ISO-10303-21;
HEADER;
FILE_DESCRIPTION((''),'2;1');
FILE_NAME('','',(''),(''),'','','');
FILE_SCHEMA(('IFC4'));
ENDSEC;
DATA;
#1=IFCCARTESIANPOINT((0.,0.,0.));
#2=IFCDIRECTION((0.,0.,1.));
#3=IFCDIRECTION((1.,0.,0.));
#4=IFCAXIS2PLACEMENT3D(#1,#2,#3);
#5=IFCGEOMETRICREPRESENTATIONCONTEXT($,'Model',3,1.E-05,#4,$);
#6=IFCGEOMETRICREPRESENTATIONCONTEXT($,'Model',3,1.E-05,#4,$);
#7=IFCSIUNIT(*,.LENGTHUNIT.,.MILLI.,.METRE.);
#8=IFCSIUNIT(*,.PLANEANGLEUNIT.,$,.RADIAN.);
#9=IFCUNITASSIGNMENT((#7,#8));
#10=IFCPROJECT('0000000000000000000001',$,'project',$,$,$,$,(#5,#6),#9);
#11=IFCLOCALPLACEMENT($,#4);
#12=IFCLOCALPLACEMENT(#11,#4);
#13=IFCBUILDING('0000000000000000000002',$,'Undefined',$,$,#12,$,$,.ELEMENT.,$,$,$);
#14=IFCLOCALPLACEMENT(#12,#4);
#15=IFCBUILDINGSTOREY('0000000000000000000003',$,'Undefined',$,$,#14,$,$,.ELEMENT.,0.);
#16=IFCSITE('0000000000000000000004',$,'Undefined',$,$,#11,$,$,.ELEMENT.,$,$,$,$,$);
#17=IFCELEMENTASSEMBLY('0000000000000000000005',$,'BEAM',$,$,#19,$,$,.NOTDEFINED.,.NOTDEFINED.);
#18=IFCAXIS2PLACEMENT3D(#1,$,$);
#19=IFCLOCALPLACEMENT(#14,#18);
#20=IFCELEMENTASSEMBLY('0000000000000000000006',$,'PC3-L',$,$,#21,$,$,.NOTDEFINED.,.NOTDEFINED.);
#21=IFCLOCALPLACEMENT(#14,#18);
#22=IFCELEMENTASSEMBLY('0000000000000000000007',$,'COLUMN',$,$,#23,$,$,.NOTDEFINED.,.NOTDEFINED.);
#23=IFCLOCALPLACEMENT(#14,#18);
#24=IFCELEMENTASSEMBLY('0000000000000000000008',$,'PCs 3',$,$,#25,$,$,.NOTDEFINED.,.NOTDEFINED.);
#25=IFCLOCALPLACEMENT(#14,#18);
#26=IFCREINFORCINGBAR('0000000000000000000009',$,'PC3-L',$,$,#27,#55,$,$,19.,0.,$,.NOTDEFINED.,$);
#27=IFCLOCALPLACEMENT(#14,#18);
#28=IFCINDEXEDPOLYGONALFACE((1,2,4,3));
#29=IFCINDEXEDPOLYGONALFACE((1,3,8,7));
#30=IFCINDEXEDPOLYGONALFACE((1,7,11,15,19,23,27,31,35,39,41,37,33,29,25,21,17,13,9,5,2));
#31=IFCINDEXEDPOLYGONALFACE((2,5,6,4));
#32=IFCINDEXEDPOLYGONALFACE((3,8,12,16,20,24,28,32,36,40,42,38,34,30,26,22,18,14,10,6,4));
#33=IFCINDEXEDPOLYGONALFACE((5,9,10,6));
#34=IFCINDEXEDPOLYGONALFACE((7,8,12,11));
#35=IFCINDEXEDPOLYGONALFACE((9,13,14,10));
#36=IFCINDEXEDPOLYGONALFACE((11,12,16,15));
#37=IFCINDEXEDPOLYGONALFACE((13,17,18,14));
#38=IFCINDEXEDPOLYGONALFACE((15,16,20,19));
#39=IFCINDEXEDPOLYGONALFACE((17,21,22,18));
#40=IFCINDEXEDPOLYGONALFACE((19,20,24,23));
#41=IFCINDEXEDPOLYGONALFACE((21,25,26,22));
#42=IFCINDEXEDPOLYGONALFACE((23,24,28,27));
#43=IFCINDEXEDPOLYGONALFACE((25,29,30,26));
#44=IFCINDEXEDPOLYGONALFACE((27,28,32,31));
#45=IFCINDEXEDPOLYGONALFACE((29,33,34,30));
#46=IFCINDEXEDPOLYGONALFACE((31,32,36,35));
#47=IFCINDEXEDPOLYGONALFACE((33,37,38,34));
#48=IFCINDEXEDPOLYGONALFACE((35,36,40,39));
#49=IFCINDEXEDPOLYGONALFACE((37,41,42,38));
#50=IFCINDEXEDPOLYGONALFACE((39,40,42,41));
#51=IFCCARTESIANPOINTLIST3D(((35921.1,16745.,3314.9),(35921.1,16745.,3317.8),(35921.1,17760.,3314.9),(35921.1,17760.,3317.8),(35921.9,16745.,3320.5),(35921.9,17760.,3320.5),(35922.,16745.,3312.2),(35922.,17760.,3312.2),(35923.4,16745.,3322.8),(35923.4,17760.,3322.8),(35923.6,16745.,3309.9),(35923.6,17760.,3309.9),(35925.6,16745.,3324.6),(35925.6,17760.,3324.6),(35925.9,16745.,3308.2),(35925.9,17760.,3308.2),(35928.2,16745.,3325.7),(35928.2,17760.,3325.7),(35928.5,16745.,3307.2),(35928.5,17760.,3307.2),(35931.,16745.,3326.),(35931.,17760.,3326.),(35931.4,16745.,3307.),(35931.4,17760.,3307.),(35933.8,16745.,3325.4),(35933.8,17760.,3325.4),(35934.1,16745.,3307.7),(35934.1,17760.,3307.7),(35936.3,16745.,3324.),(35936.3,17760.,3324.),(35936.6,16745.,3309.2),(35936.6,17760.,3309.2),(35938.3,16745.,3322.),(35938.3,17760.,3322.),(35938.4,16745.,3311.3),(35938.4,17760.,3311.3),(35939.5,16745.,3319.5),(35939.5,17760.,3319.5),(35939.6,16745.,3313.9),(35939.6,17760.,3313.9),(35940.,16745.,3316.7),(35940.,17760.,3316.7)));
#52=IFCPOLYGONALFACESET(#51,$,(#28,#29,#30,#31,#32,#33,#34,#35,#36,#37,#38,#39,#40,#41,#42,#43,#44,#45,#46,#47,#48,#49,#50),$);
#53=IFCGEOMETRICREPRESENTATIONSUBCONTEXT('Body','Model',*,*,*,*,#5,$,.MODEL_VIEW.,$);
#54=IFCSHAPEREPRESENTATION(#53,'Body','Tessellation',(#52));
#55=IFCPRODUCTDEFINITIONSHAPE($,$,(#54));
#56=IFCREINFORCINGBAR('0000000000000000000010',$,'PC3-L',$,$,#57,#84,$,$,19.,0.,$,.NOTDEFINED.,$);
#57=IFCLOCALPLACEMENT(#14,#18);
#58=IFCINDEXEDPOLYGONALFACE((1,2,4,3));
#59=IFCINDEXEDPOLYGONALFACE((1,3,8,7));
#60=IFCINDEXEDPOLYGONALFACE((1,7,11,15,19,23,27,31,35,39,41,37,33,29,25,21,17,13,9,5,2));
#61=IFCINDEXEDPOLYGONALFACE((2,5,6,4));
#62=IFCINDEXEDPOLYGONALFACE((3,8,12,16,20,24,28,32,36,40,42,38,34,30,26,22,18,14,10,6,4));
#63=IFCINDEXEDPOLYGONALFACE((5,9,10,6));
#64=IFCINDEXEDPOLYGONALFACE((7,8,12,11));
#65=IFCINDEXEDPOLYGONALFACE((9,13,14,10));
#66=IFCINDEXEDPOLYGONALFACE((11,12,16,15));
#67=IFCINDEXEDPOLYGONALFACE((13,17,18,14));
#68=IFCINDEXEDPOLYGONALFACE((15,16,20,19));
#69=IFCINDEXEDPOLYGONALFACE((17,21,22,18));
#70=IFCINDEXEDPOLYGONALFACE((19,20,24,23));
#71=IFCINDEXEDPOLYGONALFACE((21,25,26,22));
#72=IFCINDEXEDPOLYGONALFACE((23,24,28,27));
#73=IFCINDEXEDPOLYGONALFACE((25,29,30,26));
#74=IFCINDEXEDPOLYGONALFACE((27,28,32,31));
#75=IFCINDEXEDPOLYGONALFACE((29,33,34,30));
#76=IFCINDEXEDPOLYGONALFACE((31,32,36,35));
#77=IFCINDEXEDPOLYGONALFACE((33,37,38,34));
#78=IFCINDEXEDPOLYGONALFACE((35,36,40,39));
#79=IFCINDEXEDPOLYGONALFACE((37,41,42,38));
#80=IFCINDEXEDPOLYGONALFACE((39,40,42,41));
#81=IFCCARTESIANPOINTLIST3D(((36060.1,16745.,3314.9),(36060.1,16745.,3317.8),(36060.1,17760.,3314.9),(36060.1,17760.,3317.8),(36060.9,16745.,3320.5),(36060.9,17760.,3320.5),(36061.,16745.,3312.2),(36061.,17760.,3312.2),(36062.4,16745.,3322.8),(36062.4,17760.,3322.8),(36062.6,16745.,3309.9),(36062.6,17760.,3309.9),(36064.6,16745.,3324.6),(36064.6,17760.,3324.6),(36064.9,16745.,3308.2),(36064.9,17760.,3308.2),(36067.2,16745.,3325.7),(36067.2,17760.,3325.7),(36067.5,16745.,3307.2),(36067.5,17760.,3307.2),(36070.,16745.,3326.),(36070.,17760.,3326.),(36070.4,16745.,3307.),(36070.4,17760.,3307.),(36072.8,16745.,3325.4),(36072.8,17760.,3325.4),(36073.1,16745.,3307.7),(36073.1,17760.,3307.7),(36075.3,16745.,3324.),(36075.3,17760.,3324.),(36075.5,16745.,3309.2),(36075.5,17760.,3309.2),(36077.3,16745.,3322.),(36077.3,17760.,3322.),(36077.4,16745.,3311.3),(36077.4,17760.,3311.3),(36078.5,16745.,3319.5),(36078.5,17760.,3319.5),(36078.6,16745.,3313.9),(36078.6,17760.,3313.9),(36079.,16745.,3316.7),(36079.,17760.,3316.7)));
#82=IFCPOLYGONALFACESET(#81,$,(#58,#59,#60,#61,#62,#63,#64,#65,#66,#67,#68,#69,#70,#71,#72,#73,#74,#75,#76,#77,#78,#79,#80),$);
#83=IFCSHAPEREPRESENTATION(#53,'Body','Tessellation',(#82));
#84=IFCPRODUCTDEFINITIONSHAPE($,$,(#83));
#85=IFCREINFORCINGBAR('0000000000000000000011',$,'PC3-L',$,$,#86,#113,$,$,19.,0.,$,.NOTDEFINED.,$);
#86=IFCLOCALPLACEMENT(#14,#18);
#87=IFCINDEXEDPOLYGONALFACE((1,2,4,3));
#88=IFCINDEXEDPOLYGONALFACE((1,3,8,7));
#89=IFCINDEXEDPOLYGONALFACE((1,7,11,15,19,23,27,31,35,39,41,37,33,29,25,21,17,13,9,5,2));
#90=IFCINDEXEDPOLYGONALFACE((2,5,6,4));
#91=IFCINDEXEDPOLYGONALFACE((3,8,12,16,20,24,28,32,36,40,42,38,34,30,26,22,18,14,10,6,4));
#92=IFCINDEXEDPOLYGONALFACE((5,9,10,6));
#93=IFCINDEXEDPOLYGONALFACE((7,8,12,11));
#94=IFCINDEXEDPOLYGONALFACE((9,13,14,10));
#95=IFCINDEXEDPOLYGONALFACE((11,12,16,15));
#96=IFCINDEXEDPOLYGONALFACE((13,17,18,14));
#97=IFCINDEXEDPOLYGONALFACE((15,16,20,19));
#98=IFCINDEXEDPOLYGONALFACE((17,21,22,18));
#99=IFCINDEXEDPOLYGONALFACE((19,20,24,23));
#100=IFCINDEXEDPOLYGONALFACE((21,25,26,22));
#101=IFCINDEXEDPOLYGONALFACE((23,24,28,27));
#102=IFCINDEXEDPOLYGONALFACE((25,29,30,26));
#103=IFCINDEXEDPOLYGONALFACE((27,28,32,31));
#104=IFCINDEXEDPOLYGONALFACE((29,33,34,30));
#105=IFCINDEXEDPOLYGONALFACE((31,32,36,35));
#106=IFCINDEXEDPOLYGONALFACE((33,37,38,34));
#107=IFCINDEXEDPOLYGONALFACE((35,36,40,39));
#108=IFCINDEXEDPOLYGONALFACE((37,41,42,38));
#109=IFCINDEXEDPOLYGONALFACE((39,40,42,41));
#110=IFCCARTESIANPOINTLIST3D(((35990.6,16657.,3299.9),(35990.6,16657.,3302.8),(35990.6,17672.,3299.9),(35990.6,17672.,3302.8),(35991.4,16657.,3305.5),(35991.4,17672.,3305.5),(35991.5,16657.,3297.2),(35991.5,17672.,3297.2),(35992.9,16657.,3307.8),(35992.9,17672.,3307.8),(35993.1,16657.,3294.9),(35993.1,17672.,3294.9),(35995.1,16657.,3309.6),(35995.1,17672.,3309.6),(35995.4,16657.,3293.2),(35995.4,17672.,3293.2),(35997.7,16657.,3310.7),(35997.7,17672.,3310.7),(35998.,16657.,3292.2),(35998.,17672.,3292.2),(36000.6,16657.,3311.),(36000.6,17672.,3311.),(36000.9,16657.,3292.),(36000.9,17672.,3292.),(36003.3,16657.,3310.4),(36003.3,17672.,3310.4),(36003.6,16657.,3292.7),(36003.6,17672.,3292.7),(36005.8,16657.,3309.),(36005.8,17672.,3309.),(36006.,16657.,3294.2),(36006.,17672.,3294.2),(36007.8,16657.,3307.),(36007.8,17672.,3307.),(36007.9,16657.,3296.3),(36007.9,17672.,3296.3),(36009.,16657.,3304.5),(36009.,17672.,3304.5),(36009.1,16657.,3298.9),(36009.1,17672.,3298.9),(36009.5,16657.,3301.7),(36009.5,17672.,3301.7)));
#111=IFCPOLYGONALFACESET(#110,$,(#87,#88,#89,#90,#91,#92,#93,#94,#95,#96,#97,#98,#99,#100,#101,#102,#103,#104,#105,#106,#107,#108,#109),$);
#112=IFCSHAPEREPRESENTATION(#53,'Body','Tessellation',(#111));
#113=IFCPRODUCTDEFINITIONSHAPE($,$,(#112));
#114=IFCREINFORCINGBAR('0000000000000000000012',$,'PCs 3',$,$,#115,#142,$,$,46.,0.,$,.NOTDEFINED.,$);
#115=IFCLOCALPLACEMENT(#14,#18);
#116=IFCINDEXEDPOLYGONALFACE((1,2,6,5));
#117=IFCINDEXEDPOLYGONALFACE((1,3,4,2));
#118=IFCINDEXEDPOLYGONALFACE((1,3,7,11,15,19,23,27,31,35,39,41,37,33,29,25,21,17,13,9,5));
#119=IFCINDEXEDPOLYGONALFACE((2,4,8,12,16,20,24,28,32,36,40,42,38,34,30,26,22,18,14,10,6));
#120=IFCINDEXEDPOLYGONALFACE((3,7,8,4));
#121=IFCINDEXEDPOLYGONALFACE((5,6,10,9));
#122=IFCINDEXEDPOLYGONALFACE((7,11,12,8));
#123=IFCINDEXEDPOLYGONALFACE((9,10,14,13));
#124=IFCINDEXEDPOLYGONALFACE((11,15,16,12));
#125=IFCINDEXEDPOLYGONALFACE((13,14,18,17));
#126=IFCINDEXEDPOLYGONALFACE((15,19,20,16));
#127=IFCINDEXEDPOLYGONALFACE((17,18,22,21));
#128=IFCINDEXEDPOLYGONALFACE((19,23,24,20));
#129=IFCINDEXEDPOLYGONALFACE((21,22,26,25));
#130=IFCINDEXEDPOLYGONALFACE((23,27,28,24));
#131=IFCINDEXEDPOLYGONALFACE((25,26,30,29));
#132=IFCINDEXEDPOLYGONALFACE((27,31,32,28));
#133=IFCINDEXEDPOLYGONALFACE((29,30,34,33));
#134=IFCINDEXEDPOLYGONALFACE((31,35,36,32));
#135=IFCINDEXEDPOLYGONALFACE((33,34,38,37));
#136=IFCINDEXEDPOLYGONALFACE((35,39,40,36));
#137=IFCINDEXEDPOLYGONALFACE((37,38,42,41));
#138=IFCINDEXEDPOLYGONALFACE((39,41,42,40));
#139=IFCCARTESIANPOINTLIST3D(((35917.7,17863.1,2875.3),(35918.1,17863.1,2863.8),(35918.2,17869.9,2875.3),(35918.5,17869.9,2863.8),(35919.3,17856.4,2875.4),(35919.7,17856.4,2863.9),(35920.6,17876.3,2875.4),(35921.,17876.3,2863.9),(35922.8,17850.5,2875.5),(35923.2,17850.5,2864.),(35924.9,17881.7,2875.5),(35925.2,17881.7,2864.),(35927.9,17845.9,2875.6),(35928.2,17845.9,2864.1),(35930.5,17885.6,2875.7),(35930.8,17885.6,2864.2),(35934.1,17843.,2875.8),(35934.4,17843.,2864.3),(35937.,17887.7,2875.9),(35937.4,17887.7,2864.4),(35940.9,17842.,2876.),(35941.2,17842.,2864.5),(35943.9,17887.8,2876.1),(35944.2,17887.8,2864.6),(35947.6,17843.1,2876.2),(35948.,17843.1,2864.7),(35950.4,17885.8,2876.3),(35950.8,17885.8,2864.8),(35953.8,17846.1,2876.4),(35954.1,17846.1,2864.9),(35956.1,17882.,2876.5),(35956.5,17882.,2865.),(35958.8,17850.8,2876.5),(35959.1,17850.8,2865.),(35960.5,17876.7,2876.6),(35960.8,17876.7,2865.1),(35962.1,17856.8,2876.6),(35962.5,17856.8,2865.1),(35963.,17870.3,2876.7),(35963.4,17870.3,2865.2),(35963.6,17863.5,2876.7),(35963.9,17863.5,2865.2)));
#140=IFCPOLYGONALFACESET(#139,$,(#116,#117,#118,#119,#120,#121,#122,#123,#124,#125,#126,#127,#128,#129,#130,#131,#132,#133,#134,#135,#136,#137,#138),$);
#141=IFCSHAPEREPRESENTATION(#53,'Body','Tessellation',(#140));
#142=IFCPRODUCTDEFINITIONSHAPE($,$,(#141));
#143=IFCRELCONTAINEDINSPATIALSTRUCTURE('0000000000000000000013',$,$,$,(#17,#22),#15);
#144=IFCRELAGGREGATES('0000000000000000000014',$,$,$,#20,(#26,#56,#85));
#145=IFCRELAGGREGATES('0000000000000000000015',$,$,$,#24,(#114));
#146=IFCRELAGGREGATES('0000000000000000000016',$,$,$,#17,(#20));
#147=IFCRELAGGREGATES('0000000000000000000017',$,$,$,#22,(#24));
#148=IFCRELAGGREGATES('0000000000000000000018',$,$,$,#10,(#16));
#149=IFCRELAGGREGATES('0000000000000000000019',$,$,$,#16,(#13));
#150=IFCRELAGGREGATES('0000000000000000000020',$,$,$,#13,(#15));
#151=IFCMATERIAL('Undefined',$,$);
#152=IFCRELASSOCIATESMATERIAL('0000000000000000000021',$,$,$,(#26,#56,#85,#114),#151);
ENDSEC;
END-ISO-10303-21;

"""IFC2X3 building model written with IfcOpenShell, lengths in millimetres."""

from ifc_helpers import new_model, entity, si_unit, frame, origin_with_axes, place, context, subcontext, project, spatial, source, transform, mapped, material, element, aggregate, save


model = new_model("IFC2X3")

# Units and contexts
model_context_1 = context("Model", 3, precision=1e-05, world=origin_with_axes())
model_context_2 = context("Model", 3, precision=1e-05, world=origin_with_axes())
body_context = subcontext(model_context_1, "Body", "Model", "MODEL_VIEW")
ifc_project = project(units=[si_unit("LENGTHUNIT", "METRE", prefix="MILLI"), si_unit("PLANEANGLEUNIT", "RADIAN")], contexts=[model_context_1, model_context_2])

# Site, building, storey
site_placement = place(None, origin_with_axes())
site = spatial("IfcSite", under=ifc_project, at=site_placement, Name="Undefined", CompositionType="ELEMENT")
building_placement = place(site_placement, origin_with_axes())
building = spatial("IfcBuilding", under=site, at=building_placement, Name="Undefined", CompositionType="ELEMENT")
storey_placement = place(building_placement, origin_with_axes())
storey = spatial("IfcBuildingStorey", under=building, at=storey_placement, Name="Undefined", CompositionType="ELEMENT", Elevation=0.0)

# Element assemblies
assembly_1_placement = place(storey_placement, origin_with_axes())
assembly_1 = element("IfcElementAssembly", 1, at=assembly_1_placement, inside=storey, Name="BEAM", AssemblyPlace="NOTDEFINED", PredefinedType="NOTDEFINED")
assembly_2_placement = place(assembly_1_placement, origin_with_axes())
assembly_2 = element("IfcElementAssembly", 2, at=assembly_2_placement, Name="PC3-L", AssemblyPlace="NOTDEFINED", PredefinedType="NOTDEFINED")

# Element assemblies
assembly_3_placement = place(storey_placement, origin_with_axes())
assembly_3 = element("IfcElementAssembly", 3, at=assembly_3_placement, inside=storey, Name="COLUMN", AssemblyPlace="NOTDEFINED", PredefinedType="NOTDEFINED")
assembly_4_placement = place(assembly_3_placement, origin_with_axes())
assembly_4 = element("IfcElementAssembly", 4, at=assembly_4_placement, Name="PCs 3", AssemblyPlace="NOTDEFINED", PredefinedType="NOTDEFINED")

# Reinforcing bars
ifc_material_1 = material(Name="Undefined")
shared_shape_1 = source(origin_with_axes(), body_context, "Body", "AdvancedSweptSolid", [
    entity("IfcSweptDiskSolid", entity("IfcTrimmedCurve", entity("IfcLine", entity("IfcCartesianPoint", [0.0, 0.0, 0.0]), entity("IfcVector", entity("IfcDirection", [1.0, 0.0, 0.0]), 1.0)), [entity("IfcParameterValue", 0.0)], [entity("IfcParameterValue", 1015.0)], True, "PARAMETER"), 9.5, None, 0.0, 1015.0),
])
reinforcing_bar_1_placement = place(assembly_2_placement, frame((35930.5, 17760.0, 3316.5), z_axis=(0.091912, 0.0, -0.995767), x_axis=(0.0, -1.0, 0.0)))
reinforcing_bar_1 = element("IfcReinforcingBar", 5, at=reinforcing_bar_1_placement, material=ifc_material_1, Name="PC3-L", BarRole="NOTDEFINED", CrossSectionArea=0.0, NominalDiameter=19.0, context=body_context, shape_type="MappedRepresentation", body=[
    mapped(shared_shape_1, transform((0.0, 0.0, 0.0))),
])
shared_shape_2 = source(origin_with_axes(), body_context, "Body", "AdvancedSweptSolid", [
    entity("IfcSweptDiskSolid", entity("IfcTrimmedCurve", entity("IfcLine", entity("IfcCartesianPoint", [0.0, 0.0, 0.0]), entity("IfcVector", entity("IfcDirection", [1.0, 0.0, 0.0]), 1.0)), [entity("IfcParameterValue", 0.0)], [entity("IfcParameterValue", 1015.0)], True, "PARAMETER"), 9.5, None, 0.0, 1015.0),
])
reinforcing_bar_2_placement = place(assembly_2_placement, frame((36069.5, 17760.0, 3316.5), z_axis=(0.091561, 0.0, -0.995799), x_axis=(0.0, -1.0, 0.0)))
reinforcing_bar_2 = element("IfcReinforcingBar", 6, at=reinforcing_bar_2_placement, material=ifc_material_1, Name="PC3-L", BarRole="NOTDEFINED", CrossSectionArea=0.0, NominalDiameter=19.0, context=body_context, shape_type="MappedRepresentation", body=[
    mapped(shared_shape_2, transform((0.0, 0.0, 0.0))),
])
shared_shape_3 = source(origin_with_axes(), body_context, "Body", "AdvancedSweptSolid", [
    entity("IfcSweptDiskSolid", entity("IfcTrimmedCurve", entity("IfcLine", entity("IfcCartesianPoint", [0.0, 0.0, 0.0]), entity("IfcVector", entity("IfcDirection", [1.0, 0.0, 0.0]), 1.0)), [entity("IfcParameterValue", 0.0)], [entity("IfcParameterValue", 1015.0)], True, "PARAMETER"), 9.5, None, 0.0, 1015.0),
])
reinforcing_bar_3_placement = place(assembly_2_placement, frame((36000.0, 17672.0, 3301.5), z_axis=(0.091325, 0.0, -0.995821), x_axis=(0.0, -1.0, 0.0)))
reinforcing_bar_3 = element("IfcReinforcingBar", 7, at=reinforcing_bar_3_placement, material=ifc_material_1, Name="PC3-L", BarRole="NOTDEFINED", CrossSectionArea=0.0, NominalDiameter=19.0, context=body_context, shape_type="MappedRepresentation", body=[
    mapped(shared_shape_3, transform((0.0, 0.0, 0.0))),
])
aggregate(assembly_2, [reinforcing_bar_1, reinforcing_bar_2, reinforcing_bar_3])
shared_shape_4 = source(origin_with_axes(), body_context, "Body", "AdvancedSweptSolid", [
    entity("IfcSweptDiskSolid", entity("IfcTrimmedCurve", entity("IfcLine", entity("IfcCartesianPoint", [0.0, 0.0, 0.0]), entity("IfcVector", entity("IfcDirection", [1.0, 0.0, 0.0]), 1.0)), [entity("IfcParameterValue", 0.0)], [entity("IfcParameterValue", 11.5)], True, "PARAMETER"), 23.0, None, 0.0, 11.5),
])
reinforcing_bar_4_placement = place(assembly_4_placement, frame((35940.7, 17865.0, 2876.0), z_axis=(-0.442221, 0.896808, -0.013263), x_axis=(0.029977, 0.0, -0.999551)))
reinforcing_bar_4 = element("IfcReinforcingBar", 8, at=reinforcing_bar_4_placement, material=ifc_material_1, Name="PCs 3", BarRole="NOTDEFINED", CrossSectionArea=0.0, NominalDiameter=46.0, context=body_context, shape_type="MappedRepresentation", body=[
    mapped(shared_shape_4, transform((0.0, 0.0, 0.0))),
])
aggregate(assembly_4, [reinforcing_bar_4])

aggregate(assembly_1, [assembly_2])

aggregate(assembly_3, [assembly_4])

save(model, "model.ifc")
